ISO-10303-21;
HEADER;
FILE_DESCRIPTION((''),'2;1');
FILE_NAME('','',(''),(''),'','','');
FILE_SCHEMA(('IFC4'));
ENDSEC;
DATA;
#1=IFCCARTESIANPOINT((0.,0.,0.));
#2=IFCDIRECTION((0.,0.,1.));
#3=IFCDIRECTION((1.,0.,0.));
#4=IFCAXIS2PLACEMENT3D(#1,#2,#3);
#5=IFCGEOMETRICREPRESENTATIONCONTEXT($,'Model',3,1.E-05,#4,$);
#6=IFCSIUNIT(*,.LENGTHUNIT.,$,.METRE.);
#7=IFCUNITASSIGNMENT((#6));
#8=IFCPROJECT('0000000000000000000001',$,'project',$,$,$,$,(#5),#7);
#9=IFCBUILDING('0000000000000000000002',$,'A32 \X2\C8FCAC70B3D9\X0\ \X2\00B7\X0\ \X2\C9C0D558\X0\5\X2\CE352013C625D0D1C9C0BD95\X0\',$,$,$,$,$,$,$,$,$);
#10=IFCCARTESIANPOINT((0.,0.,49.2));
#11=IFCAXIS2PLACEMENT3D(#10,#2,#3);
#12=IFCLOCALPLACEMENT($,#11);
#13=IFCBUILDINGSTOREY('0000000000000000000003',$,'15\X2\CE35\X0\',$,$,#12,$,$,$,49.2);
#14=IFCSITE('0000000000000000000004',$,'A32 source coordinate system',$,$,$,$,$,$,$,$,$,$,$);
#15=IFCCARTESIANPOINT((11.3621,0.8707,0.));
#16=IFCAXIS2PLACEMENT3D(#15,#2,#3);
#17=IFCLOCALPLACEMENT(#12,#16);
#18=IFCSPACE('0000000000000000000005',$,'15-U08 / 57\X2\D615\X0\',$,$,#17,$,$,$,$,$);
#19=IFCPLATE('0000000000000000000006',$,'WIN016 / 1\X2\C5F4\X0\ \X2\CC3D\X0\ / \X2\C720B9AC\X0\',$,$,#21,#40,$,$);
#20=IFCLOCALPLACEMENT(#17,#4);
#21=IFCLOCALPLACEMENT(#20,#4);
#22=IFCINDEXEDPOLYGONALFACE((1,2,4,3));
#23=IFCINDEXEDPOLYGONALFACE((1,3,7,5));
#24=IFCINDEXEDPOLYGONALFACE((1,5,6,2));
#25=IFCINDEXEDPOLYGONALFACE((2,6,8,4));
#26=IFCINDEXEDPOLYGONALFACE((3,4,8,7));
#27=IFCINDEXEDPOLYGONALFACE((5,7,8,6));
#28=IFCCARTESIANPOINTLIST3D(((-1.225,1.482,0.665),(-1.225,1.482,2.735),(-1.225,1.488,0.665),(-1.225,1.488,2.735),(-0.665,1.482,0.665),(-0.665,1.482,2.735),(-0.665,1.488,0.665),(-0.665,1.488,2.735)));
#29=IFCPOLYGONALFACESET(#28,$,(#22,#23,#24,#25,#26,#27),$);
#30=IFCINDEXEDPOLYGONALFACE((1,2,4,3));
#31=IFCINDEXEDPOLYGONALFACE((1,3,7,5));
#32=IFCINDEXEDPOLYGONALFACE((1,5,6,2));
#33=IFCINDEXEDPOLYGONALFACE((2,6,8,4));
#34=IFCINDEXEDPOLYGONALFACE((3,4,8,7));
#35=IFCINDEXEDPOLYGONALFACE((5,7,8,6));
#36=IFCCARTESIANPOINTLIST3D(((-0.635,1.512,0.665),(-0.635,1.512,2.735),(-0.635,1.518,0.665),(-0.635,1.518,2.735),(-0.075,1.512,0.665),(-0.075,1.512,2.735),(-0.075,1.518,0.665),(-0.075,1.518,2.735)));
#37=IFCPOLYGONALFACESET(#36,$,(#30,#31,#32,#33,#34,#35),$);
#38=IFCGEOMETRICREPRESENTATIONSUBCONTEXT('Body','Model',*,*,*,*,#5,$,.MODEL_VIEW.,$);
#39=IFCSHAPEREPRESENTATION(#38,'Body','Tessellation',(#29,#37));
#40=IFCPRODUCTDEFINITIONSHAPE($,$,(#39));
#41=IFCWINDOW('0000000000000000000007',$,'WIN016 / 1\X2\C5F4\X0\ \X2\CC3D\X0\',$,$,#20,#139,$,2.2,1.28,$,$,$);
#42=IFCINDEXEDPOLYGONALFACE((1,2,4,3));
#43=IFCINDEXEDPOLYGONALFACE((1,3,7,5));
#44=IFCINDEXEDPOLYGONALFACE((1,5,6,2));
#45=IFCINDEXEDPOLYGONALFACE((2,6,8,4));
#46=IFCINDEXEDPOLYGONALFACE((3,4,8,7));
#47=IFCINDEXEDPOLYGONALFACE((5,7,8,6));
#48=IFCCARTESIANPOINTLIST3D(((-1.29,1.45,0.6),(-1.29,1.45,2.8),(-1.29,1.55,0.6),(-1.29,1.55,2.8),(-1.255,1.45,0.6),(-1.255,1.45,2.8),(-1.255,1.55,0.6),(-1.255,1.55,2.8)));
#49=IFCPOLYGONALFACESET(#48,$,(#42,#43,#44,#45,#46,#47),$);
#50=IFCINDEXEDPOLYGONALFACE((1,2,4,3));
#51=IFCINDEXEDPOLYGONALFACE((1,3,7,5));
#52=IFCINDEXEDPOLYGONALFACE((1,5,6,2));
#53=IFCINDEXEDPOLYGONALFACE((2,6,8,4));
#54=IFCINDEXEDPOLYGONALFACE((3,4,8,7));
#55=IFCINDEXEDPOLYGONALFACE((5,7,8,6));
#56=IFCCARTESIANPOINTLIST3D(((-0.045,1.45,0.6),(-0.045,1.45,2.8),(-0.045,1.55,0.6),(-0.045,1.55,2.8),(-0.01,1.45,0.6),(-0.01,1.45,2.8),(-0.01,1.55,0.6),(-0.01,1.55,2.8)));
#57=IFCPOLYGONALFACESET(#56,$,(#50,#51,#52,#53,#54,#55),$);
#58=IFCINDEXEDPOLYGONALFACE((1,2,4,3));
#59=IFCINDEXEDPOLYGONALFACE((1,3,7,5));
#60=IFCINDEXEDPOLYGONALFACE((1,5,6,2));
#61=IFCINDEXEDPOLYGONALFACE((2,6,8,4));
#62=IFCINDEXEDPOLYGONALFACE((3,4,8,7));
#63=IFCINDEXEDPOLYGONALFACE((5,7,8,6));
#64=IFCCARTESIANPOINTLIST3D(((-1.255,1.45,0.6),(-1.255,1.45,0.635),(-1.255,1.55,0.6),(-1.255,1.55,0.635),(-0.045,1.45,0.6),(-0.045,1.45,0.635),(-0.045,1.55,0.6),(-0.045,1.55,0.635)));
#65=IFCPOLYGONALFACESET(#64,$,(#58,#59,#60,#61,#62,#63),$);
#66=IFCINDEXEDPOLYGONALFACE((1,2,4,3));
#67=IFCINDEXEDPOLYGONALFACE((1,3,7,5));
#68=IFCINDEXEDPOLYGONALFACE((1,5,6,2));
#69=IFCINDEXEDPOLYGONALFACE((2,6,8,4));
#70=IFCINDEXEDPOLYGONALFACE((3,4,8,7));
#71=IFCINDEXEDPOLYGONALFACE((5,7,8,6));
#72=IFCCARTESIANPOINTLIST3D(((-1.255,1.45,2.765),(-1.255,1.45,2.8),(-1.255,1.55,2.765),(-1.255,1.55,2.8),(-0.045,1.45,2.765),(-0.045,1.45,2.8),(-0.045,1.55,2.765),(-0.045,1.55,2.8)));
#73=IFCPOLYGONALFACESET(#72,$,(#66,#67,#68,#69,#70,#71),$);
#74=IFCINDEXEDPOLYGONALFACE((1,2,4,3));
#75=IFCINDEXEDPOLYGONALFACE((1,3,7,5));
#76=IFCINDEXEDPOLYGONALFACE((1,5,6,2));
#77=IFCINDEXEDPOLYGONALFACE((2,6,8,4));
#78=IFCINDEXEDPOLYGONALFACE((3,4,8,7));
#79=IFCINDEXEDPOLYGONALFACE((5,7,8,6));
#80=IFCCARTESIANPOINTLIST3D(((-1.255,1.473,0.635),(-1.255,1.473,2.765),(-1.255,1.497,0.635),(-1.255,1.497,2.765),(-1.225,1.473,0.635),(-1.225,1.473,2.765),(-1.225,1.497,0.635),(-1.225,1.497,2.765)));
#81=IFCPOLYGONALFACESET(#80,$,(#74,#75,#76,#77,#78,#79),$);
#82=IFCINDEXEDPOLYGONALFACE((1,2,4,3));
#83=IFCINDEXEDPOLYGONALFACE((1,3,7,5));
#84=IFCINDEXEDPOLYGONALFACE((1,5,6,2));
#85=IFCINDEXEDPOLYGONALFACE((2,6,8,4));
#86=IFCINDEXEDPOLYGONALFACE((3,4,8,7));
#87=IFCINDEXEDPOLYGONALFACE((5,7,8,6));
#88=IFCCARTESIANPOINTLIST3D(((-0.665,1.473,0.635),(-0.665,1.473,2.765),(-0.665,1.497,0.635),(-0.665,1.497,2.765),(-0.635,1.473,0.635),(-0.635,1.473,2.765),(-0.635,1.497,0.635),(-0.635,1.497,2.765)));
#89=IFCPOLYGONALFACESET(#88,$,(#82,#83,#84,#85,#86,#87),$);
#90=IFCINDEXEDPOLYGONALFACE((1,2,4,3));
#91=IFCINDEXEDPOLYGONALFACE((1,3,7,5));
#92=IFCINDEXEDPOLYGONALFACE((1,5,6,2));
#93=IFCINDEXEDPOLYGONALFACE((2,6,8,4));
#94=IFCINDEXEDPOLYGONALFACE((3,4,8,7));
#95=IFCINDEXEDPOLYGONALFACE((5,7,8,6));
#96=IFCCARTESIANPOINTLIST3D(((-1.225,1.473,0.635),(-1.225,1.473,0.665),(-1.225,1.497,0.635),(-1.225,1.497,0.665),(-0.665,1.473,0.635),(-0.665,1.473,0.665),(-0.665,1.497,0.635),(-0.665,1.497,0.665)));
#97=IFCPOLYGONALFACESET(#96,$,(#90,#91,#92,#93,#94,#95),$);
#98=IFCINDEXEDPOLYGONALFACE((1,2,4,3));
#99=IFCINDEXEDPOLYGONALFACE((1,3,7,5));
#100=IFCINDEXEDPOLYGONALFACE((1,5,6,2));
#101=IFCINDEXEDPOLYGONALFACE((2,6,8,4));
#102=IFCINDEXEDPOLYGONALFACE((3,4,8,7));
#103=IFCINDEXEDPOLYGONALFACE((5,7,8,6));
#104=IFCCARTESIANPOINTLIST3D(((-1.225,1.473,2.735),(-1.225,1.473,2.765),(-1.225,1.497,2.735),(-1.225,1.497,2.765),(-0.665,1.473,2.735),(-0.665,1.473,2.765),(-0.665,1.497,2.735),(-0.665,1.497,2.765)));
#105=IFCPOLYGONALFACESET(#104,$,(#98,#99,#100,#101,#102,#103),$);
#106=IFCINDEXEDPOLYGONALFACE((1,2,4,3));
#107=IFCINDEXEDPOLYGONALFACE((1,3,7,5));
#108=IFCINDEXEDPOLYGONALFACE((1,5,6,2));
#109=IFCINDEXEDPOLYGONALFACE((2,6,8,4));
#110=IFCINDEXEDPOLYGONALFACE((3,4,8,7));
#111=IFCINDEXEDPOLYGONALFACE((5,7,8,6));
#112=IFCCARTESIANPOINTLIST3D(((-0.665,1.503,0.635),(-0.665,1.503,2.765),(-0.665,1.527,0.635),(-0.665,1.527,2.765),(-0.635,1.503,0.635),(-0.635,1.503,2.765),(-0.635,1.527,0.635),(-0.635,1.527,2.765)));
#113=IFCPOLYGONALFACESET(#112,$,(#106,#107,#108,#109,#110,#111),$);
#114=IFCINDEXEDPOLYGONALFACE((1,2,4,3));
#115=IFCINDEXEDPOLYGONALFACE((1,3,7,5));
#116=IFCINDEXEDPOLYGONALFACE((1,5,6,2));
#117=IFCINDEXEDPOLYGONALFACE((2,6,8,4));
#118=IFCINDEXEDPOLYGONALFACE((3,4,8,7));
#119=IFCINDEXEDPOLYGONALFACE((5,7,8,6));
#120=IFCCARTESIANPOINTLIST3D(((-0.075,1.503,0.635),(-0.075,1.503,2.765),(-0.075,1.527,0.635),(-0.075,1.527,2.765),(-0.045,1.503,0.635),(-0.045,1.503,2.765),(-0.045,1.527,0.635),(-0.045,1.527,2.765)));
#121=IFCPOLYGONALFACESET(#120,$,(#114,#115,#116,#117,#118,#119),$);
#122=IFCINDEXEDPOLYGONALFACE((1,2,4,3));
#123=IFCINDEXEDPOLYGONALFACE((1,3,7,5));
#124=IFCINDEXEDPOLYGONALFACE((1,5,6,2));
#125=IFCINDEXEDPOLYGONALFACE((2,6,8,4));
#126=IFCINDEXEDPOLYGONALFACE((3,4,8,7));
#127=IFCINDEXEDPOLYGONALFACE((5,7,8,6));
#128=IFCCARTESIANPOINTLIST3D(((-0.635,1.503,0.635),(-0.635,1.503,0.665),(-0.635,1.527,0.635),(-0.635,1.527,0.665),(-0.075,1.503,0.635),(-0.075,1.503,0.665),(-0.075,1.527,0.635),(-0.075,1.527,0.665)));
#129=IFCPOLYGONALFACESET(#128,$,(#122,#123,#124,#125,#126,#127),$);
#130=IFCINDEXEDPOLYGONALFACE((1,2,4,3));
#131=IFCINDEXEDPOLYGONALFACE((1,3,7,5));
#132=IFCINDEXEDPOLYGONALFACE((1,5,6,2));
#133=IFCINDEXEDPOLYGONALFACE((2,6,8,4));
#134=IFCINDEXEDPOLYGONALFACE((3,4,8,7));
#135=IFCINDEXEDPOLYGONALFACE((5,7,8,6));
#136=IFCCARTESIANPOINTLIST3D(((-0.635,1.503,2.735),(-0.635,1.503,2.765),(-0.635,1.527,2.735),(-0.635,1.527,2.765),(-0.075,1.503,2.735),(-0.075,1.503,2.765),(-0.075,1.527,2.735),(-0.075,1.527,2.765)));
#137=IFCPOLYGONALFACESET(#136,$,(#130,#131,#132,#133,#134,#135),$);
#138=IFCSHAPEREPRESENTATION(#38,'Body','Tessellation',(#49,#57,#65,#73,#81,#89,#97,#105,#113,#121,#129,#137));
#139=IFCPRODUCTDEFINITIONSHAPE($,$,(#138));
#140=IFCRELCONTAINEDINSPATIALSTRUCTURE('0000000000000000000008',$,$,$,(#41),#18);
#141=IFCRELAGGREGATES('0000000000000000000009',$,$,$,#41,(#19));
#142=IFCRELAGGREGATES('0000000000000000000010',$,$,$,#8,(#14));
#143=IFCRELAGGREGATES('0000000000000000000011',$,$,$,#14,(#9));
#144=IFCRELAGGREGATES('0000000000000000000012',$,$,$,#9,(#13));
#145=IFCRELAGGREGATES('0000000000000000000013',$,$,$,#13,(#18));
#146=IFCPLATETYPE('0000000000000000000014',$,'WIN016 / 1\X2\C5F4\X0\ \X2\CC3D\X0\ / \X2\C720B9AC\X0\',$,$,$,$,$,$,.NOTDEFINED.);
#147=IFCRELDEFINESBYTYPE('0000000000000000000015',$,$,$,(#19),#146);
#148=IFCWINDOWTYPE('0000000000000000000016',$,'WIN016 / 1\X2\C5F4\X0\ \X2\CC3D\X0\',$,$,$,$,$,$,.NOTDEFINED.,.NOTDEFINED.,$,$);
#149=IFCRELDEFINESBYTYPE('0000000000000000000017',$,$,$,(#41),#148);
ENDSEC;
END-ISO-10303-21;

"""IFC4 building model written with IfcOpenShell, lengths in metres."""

from ifc_helpers import new_model, si_unit, frame, origin, origin_with_axes, place, context, subcontext, project, spatial, polyline, outline, extrude, source, transform, mapped, type_object, type_shapes, element, aggregate, save


model = new_model("IFC4")

# Units and contexts
model_context = context("Model", 3, precision=1e-05, world=origin_with_axes())
body_context = subcontext(model_context, "Body", "Model", "MODEL_VIEW")
ifc_project = project(units=[si_unit("LENGTHUNIT", "METRE")], contexts=[model_context])

# Plate
storey_placement = place(None, frame((0.0, 0.0, 49.2), z_axis=(0.0, 0.0, 1.0), x_axis=(1.0, 0.0, 0.0)))
space_placement = place(storey_placement, frame((11.3621, 0.8707, 0.0), z_axis=(0.0, 0.0, 1.0), x_axis=(1.0, 0.0, 0.0)))
plate_type_1 = type_object("IfcPlateType", Name="WIN016 / 1열 창 / 유리", PredefinedType="NOTDEFINED")
shared_shape_1 = source(origin(), body_context, "Body", "SweptSolid", [
    extrude(outline(polyline([(-1.225, 1.482), (-1.225, 1.488), (-0.665, 1.488), (-0.665, 1.482), (-1.225, 1.482)])), frame((0.0, 0.0, 0.665)), (0.0, 0.0, 1.0), 2.07),
    extrude(outline(polyline([(-0.635, 1.512), (-0.635, 1.518), (-0.075, 1.518), (-0.075, 1.512), (-0.635, 1.512)])), frame((0.0, 0.0, 0.665)), (0.0, 0.0, 1.0), 2.07),
])
type_shapes(plate_type_1, [shared_shape_1])
window_1_placement = place(space_placement, origin_with_axes())
plate_1_placement = place(window_1_placement, origin_with_axes())
plate_1 = element("IfcPlate", 1, at=plate_1_placement, type_object=plate_type_1, Name="WIN016 / 1열 창 / 유리", context=body_context, shape_type="MappedRepresentation", body=[
    mapped(shared_shape_1, transform((0.0, 0.0, 0.0), scale=1.0)),
])

# Site, building, storey, space
site = spatial("IfcSite", under=ifc_project, Name="A32 source coordinate system")
building = spatial("IfcBuilding", under=site, Name="A32 주거동 · 지하5층–옥탑지붕")
storey = spatial("IfcBuildingStorey", under=building, at=storey_placement, Name="15층", Elevation=49.2)
space = spatial("IfcSpace", under=storey, at=space_placement, Name="15-U08 / 57형")

# Window
window_type_1 = type_object("IfcWindowType", Name="WIN016 / 1열 창", PartitioningType="NOTDEFINED", PredefinedType="NOTDEFINED")
shared_shape_2 = source(origin(), body_context, "Body", "SweptSolid", [
    extrude(outline(polyline([(-1.29, 1.45), (-1.29, 1.55), (-1.255, 1.55), (-1.255, 1.45), (-1.29, 1.45)])), frame((0.0, 0.0, 0.6)), (0.0, 0.0, 1.0), 2.2),
    extrude(outline(polyline([(-0.045, 1.45), (-0.045, 1.55), (-0.01, 1.55), (-0.01, 1.45), (-0.045, 1.45)])), frame((0.0, 0.0, 0.6)), (0.0, 0.0, 1.0), 2.2),
    extrude(outline(polyline([(-1.255, 1.45), (-1.255, 1.55), (-0.045, 1.55), (-0.045, 1.45), (-1.255, 1.45)])), frame((0.0, 0.0, 0.6)), (0.0, 0.0, 1.0), 0.035),
    extrude(outline(polyline([(-1.255, 1.45), (-1.255, 1.55), (-0.045, 1.55), (-0.045, 1.45), (-1.255, 1.45)])), frame((0.0, 0.0, 2.765)), (0.0, 0.0, 1.0), 0.035),
    extrude(outline(polyline([(-1.255, 1.473), (-1.255, 1.497), (-1.225, 1.497), (-1.225, 1.473), (-1.255, 1.473)])), frame((0.0, 0.0, 0.635)), (0.0, 0.0, 1.0), 2.13),
    extrude(outline(polyline([(-0.665, 1.473), (-0.665, 1.497), (-0.635, 1.497), (-0.635, 1.473), (-0.665, 1.473)])), frame((0.0, 0.0, 0.635)), (0.0, 0.0, 1.0), 2.13),
    extrude(outline(polyline([(-1.225, 1.473), (-1.225, 1.497), (-0.665, 1.497), (-0.665, 1.473), (-1.225, 1.473)])), frame((0.0, 0.0, 0.635)), (0.0, 0.0, 1.0), 0.03),
    extrude(outline(polyline([(-1.225, 1.473), (-1.225, 1.497), (-0.665, 1.497), (-0.665, 1.473), (-1.225, 1.473)])), frame((0.0, 0.0, 2.735)), (0.0, 0.0, 1.0), 0.03),
    extrude(outline(polyline([(-0.665, 1.503), (-0.665, 1.527), (-0.635, 1.527), (-0.635, 1.503), (-0.665, 1.503)])), frame((0.0, 0.0, 0.635)), (0.0, 0.0, 1.0), 2.13),
    extrude(outline(polyline([(-0.075, 1.503), (-0.075, 1.527), (-0.045, 1.527), (-0.045, 1.503), (-0.075, 1.503)])), frame((0.0, 0.0, 0.635)), (0.0, 0.0, 1.0), 2.13),
    extrude(outline(polyline([(-0.635, 1.503), (-0.635, 1.527), (-0.075, 1.527), (-0.075, 1.503), (-0.635, 1.503)])), frame((0.0, 0.0, 0.635)), (0.0, 0.0, 1.0), 0.03),
    extrude(outline(polyline([(-0.635, 1.503), (-0.635, 1.527), (-0.075, 1.527), (-0.075, 1.503), (-0.635, 1.503)])), frame((0.0, 0.0, 2.735)), (0.0, 0.0, 1.0), 0.03),
])
type_shapes(window_type_1, [shared_shape_2])
window_1 = element("IfcWindow", 2, at=window_1_placement, inside=space, type_object=window_type_1, Name="WIN016 / 1열 창", OverallHeight=2.2, OverallWidth=1.28, context=body_context, shape_type="MappedRepresentation", body=[
    mapped(shared_shape_2, transform((0.0, 0.0, 0.0), scale=1.0)),
])
aggregate(window_1, [plate_1])

save(model, "model.ifc")
